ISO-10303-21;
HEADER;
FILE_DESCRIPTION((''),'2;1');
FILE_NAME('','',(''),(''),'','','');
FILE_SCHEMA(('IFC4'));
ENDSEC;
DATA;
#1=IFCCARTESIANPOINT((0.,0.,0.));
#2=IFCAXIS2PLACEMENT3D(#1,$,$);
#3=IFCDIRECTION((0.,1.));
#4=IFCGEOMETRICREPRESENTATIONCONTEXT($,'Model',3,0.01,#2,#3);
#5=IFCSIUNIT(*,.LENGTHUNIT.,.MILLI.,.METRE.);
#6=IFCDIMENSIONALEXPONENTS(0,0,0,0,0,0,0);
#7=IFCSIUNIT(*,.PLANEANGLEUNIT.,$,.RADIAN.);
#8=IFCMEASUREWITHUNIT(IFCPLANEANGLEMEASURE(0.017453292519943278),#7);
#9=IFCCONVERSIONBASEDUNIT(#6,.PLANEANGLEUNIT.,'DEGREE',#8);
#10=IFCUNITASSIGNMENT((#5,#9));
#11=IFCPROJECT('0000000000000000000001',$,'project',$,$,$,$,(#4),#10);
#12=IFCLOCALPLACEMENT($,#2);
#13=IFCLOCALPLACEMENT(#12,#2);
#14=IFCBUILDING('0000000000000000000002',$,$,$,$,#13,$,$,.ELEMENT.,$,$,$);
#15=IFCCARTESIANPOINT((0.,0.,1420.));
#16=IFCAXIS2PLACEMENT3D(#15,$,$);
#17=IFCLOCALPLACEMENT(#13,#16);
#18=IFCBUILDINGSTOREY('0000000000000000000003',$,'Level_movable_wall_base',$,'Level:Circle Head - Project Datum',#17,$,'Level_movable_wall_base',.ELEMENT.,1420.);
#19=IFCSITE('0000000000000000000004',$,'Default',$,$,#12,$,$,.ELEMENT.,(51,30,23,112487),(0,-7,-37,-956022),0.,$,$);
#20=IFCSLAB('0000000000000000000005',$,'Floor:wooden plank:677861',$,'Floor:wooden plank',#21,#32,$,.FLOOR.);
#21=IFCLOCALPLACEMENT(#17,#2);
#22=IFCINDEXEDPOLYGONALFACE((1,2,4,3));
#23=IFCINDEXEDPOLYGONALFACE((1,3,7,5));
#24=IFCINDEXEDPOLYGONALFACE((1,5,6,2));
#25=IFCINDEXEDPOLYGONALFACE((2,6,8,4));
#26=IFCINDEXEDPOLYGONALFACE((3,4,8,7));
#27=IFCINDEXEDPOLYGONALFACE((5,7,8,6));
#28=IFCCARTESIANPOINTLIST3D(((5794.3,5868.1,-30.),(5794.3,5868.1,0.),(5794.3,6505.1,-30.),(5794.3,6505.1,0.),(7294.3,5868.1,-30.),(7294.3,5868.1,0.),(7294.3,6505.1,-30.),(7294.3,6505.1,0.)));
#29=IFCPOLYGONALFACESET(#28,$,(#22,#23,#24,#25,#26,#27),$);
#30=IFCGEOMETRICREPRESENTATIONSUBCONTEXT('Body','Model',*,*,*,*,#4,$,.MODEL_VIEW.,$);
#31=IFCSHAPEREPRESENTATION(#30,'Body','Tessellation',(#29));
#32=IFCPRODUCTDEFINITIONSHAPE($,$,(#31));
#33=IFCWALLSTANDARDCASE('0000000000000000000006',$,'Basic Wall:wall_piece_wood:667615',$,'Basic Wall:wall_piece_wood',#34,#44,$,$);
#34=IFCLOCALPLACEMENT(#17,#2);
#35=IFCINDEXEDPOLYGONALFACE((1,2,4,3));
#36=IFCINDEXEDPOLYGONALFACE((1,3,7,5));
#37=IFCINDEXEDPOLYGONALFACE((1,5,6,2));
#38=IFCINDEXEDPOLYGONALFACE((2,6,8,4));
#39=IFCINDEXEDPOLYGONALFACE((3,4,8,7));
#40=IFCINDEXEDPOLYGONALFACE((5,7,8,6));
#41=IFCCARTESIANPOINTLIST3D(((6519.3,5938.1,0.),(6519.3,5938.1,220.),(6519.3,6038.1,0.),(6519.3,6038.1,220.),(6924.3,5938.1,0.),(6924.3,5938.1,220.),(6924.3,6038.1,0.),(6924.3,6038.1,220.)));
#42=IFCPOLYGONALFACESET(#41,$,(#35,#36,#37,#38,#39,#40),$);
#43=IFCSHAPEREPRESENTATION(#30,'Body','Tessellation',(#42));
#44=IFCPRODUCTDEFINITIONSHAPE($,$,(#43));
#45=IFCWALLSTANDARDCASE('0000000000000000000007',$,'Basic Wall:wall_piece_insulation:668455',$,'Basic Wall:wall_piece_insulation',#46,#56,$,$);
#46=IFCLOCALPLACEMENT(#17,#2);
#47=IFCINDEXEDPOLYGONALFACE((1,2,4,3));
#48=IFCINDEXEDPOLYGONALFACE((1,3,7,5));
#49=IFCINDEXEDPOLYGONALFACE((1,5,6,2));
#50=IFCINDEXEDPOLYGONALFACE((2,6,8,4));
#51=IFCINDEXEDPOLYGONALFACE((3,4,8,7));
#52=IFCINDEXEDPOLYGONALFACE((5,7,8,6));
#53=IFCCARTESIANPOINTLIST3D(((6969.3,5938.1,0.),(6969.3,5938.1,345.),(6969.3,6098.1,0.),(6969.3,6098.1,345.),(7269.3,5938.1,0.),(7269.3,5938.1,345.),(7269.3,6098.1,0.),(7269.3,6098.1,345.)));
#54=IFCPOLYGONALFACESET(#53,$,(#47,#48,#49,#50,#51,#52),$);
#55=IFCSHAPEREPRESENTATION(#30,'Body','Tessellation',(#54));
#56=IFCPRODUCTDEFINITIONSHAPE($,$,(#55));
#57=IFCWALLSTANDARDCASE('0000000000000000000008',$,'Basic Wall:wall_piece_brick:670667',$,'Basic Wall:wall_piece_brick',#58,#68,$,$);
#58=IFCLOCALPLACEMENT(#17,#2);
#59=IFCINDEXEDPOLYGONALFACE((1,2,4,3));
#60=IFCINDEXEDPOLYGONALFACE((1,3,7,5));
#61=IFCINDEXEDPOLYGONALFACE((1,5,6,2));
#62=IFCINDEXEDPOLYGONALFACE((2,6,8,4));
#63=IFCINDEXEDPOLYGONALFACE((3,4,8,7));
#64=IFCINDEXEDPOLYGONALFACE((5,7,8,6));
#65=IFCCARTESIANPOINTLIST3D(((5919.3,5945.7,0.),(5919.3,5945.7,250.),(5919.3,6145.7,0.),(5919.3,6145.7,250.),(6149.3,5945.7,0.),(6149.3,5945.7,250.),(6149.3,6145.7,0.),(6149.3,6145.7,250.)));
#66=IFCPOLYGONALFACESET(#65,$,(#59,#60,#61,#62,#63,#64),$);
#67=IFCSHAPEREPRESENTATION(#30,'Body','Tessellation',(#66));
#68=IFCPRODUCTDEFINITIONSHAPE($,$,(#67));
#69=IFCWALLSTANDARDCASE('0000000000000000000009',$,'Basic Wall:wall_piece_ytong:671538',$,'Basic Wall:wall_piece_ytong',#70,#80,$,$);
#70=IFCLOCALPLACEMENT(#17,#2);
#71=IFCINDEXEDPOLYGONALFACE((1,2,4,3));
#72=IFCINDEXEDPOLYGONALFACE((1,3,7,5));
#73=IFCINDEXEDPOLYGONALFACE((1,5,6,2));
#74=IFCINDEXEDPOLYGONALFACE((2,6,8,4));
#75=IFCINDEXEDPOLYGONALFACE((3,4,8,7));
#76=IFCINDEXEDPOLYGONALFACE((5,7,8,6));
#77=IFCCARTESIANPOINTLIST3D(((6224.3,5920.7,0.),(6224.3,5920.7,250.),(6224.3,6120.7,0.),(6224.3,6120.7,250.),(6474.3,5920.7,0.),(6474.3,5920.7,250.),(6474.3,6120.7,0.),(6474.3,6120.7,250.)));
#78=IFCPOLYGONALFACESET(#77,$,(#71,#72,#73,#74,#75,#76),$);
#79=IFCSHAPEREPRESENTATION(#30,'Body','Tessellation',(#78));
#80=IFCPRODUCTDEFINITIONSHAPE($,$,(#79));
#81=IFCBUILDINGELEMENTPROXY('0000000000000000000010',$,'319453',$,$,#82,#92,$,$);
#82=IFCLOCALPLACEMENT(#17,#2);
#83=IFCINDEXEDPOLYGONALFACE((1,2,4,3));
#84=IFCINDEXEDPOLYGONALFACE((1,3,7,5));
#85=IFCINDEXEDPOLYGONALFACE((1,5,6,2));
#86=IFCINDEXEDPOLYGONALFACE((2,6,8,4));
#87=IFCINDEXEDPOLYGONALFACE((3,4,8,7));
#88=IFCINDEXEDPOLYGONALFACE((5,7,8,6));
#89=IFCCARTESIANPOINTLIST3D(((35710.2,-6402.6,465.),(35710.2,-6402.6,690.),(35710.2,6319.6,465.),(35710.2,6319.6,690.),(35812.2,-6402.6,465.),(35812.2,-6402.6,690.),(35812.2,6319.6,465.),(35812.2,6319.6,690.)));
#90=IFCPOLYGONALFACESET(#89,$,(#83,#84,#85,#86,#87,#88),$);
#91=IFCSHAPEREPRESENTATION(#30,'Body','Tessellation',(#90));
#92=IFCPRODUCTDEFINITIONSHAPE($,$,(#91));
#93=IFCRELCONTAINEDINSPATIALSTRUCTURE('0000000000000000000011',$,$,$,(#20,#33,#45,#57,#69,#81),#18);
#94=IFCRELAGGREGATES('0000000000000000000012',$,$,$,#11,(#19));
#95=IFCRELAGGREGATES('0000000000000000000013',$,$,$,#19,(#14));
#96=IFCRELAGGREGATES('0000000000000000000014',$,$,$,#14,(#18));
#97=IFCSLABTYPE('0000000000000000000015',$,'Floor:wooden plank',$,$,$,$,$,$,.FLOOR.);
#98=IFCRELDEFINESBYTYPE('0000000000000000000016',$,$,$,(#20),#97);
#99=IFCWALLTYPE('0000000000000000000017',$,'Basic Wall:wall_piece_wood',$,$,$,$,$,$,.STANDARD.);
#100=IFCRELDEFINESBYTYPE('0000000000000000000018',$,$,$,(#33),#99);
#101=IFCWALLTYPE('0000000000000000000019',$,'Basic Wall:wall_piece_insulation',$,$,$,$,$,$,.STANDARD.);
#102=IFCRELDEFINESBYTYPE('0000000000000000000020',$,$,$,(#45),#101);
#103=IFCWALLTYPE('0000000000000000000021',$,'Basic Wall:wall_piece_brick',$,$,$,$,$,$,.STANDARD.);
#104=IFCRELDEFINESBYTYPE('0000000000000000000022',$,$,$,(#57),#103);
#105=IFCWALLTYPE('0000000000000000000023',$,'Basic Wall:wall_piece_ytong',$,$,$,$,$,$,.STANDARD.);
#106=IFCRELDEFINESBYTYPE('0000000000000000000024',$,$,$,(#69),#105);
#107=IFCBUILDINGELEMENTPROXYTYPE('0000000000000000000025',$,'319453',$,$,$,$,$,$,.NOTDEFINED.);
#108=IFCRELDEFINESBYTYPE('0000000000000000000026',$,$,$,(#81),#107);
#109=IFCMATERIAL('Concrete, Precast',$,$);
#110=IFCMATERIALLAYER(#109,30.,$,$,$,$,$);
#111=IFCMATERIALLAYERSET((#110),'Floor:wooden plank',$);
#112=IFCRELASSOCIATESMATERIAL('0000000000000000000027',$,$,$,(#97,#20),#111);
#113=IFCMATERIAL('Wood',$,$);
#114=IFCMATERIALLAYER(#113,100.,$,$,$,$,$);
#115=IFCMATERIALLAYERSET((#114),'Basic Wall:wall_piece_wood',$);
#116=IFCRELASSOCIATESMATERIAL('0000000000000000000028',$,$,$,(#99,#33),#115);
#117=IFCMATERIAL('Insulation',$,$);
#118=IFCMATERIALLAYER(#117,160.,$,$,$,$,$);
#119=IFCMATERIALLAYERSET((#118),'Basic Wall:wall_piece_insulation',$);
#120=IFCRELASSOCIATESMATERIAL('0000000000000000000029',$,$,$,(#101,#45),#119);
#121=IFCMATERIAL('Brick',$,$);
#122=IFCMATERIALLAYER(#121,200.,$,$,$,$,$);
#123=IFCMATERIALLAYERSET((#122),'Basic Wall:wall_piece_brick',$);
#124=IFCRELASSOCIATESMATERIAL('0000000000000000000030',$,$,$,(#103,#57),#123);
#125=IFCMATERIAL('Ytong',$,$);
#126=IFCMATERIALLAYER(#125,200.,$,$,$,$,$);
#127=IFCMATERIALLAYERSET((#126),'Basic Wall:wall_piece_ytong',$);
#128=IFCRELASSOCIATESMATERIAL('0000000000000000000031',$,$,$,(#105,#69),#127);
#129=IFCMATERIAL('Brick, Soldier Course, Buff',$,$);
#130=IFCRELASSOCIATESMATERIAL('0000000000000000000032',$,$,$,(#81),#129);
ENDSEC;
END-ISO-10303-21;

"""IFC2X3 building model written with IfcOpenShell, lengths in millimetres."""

from ifc_helpers import new_model, entity, si_unit, converted_unit, direction, frame, frame_2d, origin, place, context, subcontext, project, spatial, rectangle, extrude, material, layer, layer_set, layer_usage, type_object, element, save


model = new_model("IFC2X3")

# Units and contexts
model_context = context("Model", 3, precision=0.01, world=origin(), true_north=direction((0.0, 1.0)))
body_context = subcontext(model_context, "Body", "Model", "MODEL_VIEW")
ifc_project = project(units=[si_unit("LENGTHUNIT", "METRE", prefix="MILLI"), converted_unit("PLANEANGLEUNIT", "DEGREE", entity("IfcPlaneAngleMeasure", 0.017453292519943278), si_unit("PLANEANGLEUNIT", "RADIAN"), dimensions=[0, 0, 0, 0, 0, 0, 0])], contexts=[model_context])

# Site, building, storey
site_placement = place(None, origin())
site = spatial("IfcSite", under=ifc_project, at=site_placement, Name="Default", CompositionType="ELEMENT", RefLatitude=(51, 30, 23, 112487), RefLongitude=(0, -7, -37, -956022), RefElevation=0.0)
building_placement = place(site_placement, origin())
building = spatial("IfcBuilding", under=site, at=building_placement, CompositionType="ELEMENT")
storey_placement = place(building_placement, frame((0.0, 0.0, 1420.0)))
storey = spatial("IfcBuildingStorey", under=building, at=storey_placement, Name="Level_movable_wall_base", ObjectType="Level:Circle Head - Project Datum", LongName="Level_movable_wall_base", CompositionType="ELEMENT", Elevation=1420.0)

# Slab
ifc_material_1 = material(Name="Concrete, Precast")
ifc_layer_1 = layer(ifc_material_1, 30.0)
ifc_layer_set_1 = layer_set([ifc_layer_1], Name="Floor:wooden plank")
ifc_layer_usage_1 = layer_usage(ifc_layer_set_1, "AXIS3", "POSITIVE", 0.0)
slab_type = type_object("IfcSlabType", Name="Floor:wooden plank", PredefinedType="FLOOR", material=ifc_layer_set_1)
slab_placement = place(storey_placement, origin())
element("IfcSlab", 1, at=slab_placement, inside=storey, type_object=slab_type, material=ifc_layer_usage_1, Name="Floor:wooden plank:677861", ObjectType="Floor:wooden plank", PredefinedType="FLOOR", context=body_context, shape_type="SweptSolid", body=[
    extrude(rectangle(XDim=637.0, YDim=1500.0, at=frame_2d((0.0, 0.0), x_axis=(1.0, 0.0))), frame((6544.3, 6186.6, 0.0), z_axis=(0.0, 0.0, -1.0), x_axis=(0.0, 1.0, 0.0)), (0.0, 0.0, 1.0), 30.0),
])

# Walls
ifc_material_2 = material(Name="Wood")
ifc_layer_2 = layer(ifc_material_2, 100.0)
ifc_layer_set_2 = layer_set([ifc_layer_2], Name="Basic Wall:wall_piece_wood")
ifc_layer_usage_2 = layer_usage(ifc_layer_set_2, "AXIS2", "NEGATIVE", 50.0)
wall_type_1 = type_object("IfcWallType", Name="Basic Wall:wall_piece_wood", PredefinedType="STANDARD", material=ifc_layer_set_2)
wall_1_placement = place(storey_placement, frame((6519.3, 5988.1, 0.0)))
element("IfcWallStandardCase", 2, at=wall_1_placement, inside=storey, type_object=wall_type_1, material=ifc_layer_usage_2, Name="Basic Wall:wall_piece_wood:667615", ObjectType="Basic Wall:wall_piece_wood", context=body_context, shape_type="SweptSolid", body=[
    extrude(rectangle(XDim=405.0, YDim=100.0, at=frame_2d((202.5, 0.0), x_axis=(-1.0, 0.0))), origin(), (0.0, 0.0, 1.0), 220.0),
])
ifc_material_3 = material(Name="Insulation")
ifc_layer_3 = layer(ifc_material_3, 160.0)
ifc_layer_set_3 = layer_set([ifc_layer_3], Name="Basic Wall:wall_piece_insulation")
ifc_layer_usage_3 = layer_usage(ifc_layer_set_3, "AXIS2", "NEGATIVE", 80.0)
wall_type_2 = type_object("IfcWallType", Name="Basic Wall:wall_piece_insulation", PredefinedType="STANDARD", material=ifc_layer_set_3)
wall_2_placement = place(storey_placement, frame((6969.3, 6018.1, 0.0)))
element("IfcWallStandardCase", 3, at=wall_2_placement, inside=storey, type_object=wall_type_2, material=ifc_layer_usage_3, Name="Basic Wall:wall_piece_insulation:668455", ObjectType="Basic Wall:wall_piece_insulation", context=body_context, shape_type="SweptSolid", body=[
    extrude(rectangle(XDim=300.0, YDim=160.0, at=frame_2d((150.0, 0.0), x_axis=(-1.0, 0.0))), origin(), (0.0, 0.0, 1.0), 345.0),
])
ifc_material_4 = material(Name="Brick")
ifc_layer_4 = layer(ifc_material_4, 200.0)
ifc_layer_set_4 = layer_set([ifc_layer_4], Name="Basic Wall:wall_piece_brick")
ifc_layer_usage_4 = layer_usage(ifc_layer_set_4, "AXIS2", "NEGATIVE", 100.0)
wall_type_3 = type_object("IfcWallType", Name="Basic Wall:wall_piece_brick", PredefinedType="STANDARD", material=ifc_layer_set_4)
wall_3_placement = place(storey_placement, frame((5919.3, 6045.7, 0.0)))
element("IfcWallStandardCase", 4, at=wall_3_placement, inside=storey, type_object=wall_type_3, material=ifc_layer_usage_4, Name="Basic Wall:wall_piece_brick:670667", ObjectType="Basic Wall:wall_piece_brick", context=body_context, shape_type="SweptSolid", body=[
    extrude(rectangle(XDim=230.0, YDim=200.0, at=frame_2d((115.0, 0.0), x_axis=(-1.0, 0.0))), origin(), (0.0, 0.0, 1.0), 250.0),
])
ifc_material_5 = material(Name="Ytong")
ifc_layer_5 = layer(ifc_material_5, 200.0)
ifc_layer_set_5 = layer_set([ifc_layer_5], Name="Basic Wall:wall_piece_ytong")
ifc_layer_usage_5 = layer_usage(ifc_layer_set_5, "AXIS2", "NEGATIVE", 100.0)
wall_type_4 = type_object("IfcWallType", Name="Basic Wall:wall_piece_ytong", PredefinedType="STANDARD", material=ifc_layer_set_5)
wall_4_placement = place(storey_placement, frame((6224.3, 6020.7, 0.0)))
element("IfcWallStandardCase", 5, at=wall_4_placement, inside=storey, type_object=wall_type_4, material=ifc_layer_usage_5, Name="Basic Wall:wall_piece_ytong:671538", ObjectType="Basic Wall:wall_piece_ytong", context=body_context, shape_type="SweptSolid", body=[
    extrude(rectangle(XDim=250.0, YDim=200.0, at=frame_2d((125.0, 0.0), x_axis=(-1.0, 0.0))), origin(), (0.0, 0.0, 1.0), 250.0),
])

# Building element proxy
ifc_material_6 = material(Name="Brick, Soldier Course, Buff")
building_element_proxy_type = type_object("IfcBuildingElementProxyType", Name="319453", PredefinedType="NOTDEFINED")
proxy_placement = place(storey_placement, origin())
element("IfcBuildingElementProxy", 6, at=proxy_placement, inside=storey, type_object=building_element_proxy_type, material=ifc_material_6, Name="319453", context=body_context, shape_type="SweptSolid", body=[
    extrude(rectangle(XDim=12722.3, YDim=102.0, at=frame_2d((0.0, 0.0), x_axis=(1.0, 0.0))), frame((35761.2, -41.5, 465.0), z_axis=(0.0, 0.0, 1.0), x_axis=(0.0, -1.0, 0.0)), (0.0, 0.0, 1.0), 225.0),
])

save(model, "model.ifc")
